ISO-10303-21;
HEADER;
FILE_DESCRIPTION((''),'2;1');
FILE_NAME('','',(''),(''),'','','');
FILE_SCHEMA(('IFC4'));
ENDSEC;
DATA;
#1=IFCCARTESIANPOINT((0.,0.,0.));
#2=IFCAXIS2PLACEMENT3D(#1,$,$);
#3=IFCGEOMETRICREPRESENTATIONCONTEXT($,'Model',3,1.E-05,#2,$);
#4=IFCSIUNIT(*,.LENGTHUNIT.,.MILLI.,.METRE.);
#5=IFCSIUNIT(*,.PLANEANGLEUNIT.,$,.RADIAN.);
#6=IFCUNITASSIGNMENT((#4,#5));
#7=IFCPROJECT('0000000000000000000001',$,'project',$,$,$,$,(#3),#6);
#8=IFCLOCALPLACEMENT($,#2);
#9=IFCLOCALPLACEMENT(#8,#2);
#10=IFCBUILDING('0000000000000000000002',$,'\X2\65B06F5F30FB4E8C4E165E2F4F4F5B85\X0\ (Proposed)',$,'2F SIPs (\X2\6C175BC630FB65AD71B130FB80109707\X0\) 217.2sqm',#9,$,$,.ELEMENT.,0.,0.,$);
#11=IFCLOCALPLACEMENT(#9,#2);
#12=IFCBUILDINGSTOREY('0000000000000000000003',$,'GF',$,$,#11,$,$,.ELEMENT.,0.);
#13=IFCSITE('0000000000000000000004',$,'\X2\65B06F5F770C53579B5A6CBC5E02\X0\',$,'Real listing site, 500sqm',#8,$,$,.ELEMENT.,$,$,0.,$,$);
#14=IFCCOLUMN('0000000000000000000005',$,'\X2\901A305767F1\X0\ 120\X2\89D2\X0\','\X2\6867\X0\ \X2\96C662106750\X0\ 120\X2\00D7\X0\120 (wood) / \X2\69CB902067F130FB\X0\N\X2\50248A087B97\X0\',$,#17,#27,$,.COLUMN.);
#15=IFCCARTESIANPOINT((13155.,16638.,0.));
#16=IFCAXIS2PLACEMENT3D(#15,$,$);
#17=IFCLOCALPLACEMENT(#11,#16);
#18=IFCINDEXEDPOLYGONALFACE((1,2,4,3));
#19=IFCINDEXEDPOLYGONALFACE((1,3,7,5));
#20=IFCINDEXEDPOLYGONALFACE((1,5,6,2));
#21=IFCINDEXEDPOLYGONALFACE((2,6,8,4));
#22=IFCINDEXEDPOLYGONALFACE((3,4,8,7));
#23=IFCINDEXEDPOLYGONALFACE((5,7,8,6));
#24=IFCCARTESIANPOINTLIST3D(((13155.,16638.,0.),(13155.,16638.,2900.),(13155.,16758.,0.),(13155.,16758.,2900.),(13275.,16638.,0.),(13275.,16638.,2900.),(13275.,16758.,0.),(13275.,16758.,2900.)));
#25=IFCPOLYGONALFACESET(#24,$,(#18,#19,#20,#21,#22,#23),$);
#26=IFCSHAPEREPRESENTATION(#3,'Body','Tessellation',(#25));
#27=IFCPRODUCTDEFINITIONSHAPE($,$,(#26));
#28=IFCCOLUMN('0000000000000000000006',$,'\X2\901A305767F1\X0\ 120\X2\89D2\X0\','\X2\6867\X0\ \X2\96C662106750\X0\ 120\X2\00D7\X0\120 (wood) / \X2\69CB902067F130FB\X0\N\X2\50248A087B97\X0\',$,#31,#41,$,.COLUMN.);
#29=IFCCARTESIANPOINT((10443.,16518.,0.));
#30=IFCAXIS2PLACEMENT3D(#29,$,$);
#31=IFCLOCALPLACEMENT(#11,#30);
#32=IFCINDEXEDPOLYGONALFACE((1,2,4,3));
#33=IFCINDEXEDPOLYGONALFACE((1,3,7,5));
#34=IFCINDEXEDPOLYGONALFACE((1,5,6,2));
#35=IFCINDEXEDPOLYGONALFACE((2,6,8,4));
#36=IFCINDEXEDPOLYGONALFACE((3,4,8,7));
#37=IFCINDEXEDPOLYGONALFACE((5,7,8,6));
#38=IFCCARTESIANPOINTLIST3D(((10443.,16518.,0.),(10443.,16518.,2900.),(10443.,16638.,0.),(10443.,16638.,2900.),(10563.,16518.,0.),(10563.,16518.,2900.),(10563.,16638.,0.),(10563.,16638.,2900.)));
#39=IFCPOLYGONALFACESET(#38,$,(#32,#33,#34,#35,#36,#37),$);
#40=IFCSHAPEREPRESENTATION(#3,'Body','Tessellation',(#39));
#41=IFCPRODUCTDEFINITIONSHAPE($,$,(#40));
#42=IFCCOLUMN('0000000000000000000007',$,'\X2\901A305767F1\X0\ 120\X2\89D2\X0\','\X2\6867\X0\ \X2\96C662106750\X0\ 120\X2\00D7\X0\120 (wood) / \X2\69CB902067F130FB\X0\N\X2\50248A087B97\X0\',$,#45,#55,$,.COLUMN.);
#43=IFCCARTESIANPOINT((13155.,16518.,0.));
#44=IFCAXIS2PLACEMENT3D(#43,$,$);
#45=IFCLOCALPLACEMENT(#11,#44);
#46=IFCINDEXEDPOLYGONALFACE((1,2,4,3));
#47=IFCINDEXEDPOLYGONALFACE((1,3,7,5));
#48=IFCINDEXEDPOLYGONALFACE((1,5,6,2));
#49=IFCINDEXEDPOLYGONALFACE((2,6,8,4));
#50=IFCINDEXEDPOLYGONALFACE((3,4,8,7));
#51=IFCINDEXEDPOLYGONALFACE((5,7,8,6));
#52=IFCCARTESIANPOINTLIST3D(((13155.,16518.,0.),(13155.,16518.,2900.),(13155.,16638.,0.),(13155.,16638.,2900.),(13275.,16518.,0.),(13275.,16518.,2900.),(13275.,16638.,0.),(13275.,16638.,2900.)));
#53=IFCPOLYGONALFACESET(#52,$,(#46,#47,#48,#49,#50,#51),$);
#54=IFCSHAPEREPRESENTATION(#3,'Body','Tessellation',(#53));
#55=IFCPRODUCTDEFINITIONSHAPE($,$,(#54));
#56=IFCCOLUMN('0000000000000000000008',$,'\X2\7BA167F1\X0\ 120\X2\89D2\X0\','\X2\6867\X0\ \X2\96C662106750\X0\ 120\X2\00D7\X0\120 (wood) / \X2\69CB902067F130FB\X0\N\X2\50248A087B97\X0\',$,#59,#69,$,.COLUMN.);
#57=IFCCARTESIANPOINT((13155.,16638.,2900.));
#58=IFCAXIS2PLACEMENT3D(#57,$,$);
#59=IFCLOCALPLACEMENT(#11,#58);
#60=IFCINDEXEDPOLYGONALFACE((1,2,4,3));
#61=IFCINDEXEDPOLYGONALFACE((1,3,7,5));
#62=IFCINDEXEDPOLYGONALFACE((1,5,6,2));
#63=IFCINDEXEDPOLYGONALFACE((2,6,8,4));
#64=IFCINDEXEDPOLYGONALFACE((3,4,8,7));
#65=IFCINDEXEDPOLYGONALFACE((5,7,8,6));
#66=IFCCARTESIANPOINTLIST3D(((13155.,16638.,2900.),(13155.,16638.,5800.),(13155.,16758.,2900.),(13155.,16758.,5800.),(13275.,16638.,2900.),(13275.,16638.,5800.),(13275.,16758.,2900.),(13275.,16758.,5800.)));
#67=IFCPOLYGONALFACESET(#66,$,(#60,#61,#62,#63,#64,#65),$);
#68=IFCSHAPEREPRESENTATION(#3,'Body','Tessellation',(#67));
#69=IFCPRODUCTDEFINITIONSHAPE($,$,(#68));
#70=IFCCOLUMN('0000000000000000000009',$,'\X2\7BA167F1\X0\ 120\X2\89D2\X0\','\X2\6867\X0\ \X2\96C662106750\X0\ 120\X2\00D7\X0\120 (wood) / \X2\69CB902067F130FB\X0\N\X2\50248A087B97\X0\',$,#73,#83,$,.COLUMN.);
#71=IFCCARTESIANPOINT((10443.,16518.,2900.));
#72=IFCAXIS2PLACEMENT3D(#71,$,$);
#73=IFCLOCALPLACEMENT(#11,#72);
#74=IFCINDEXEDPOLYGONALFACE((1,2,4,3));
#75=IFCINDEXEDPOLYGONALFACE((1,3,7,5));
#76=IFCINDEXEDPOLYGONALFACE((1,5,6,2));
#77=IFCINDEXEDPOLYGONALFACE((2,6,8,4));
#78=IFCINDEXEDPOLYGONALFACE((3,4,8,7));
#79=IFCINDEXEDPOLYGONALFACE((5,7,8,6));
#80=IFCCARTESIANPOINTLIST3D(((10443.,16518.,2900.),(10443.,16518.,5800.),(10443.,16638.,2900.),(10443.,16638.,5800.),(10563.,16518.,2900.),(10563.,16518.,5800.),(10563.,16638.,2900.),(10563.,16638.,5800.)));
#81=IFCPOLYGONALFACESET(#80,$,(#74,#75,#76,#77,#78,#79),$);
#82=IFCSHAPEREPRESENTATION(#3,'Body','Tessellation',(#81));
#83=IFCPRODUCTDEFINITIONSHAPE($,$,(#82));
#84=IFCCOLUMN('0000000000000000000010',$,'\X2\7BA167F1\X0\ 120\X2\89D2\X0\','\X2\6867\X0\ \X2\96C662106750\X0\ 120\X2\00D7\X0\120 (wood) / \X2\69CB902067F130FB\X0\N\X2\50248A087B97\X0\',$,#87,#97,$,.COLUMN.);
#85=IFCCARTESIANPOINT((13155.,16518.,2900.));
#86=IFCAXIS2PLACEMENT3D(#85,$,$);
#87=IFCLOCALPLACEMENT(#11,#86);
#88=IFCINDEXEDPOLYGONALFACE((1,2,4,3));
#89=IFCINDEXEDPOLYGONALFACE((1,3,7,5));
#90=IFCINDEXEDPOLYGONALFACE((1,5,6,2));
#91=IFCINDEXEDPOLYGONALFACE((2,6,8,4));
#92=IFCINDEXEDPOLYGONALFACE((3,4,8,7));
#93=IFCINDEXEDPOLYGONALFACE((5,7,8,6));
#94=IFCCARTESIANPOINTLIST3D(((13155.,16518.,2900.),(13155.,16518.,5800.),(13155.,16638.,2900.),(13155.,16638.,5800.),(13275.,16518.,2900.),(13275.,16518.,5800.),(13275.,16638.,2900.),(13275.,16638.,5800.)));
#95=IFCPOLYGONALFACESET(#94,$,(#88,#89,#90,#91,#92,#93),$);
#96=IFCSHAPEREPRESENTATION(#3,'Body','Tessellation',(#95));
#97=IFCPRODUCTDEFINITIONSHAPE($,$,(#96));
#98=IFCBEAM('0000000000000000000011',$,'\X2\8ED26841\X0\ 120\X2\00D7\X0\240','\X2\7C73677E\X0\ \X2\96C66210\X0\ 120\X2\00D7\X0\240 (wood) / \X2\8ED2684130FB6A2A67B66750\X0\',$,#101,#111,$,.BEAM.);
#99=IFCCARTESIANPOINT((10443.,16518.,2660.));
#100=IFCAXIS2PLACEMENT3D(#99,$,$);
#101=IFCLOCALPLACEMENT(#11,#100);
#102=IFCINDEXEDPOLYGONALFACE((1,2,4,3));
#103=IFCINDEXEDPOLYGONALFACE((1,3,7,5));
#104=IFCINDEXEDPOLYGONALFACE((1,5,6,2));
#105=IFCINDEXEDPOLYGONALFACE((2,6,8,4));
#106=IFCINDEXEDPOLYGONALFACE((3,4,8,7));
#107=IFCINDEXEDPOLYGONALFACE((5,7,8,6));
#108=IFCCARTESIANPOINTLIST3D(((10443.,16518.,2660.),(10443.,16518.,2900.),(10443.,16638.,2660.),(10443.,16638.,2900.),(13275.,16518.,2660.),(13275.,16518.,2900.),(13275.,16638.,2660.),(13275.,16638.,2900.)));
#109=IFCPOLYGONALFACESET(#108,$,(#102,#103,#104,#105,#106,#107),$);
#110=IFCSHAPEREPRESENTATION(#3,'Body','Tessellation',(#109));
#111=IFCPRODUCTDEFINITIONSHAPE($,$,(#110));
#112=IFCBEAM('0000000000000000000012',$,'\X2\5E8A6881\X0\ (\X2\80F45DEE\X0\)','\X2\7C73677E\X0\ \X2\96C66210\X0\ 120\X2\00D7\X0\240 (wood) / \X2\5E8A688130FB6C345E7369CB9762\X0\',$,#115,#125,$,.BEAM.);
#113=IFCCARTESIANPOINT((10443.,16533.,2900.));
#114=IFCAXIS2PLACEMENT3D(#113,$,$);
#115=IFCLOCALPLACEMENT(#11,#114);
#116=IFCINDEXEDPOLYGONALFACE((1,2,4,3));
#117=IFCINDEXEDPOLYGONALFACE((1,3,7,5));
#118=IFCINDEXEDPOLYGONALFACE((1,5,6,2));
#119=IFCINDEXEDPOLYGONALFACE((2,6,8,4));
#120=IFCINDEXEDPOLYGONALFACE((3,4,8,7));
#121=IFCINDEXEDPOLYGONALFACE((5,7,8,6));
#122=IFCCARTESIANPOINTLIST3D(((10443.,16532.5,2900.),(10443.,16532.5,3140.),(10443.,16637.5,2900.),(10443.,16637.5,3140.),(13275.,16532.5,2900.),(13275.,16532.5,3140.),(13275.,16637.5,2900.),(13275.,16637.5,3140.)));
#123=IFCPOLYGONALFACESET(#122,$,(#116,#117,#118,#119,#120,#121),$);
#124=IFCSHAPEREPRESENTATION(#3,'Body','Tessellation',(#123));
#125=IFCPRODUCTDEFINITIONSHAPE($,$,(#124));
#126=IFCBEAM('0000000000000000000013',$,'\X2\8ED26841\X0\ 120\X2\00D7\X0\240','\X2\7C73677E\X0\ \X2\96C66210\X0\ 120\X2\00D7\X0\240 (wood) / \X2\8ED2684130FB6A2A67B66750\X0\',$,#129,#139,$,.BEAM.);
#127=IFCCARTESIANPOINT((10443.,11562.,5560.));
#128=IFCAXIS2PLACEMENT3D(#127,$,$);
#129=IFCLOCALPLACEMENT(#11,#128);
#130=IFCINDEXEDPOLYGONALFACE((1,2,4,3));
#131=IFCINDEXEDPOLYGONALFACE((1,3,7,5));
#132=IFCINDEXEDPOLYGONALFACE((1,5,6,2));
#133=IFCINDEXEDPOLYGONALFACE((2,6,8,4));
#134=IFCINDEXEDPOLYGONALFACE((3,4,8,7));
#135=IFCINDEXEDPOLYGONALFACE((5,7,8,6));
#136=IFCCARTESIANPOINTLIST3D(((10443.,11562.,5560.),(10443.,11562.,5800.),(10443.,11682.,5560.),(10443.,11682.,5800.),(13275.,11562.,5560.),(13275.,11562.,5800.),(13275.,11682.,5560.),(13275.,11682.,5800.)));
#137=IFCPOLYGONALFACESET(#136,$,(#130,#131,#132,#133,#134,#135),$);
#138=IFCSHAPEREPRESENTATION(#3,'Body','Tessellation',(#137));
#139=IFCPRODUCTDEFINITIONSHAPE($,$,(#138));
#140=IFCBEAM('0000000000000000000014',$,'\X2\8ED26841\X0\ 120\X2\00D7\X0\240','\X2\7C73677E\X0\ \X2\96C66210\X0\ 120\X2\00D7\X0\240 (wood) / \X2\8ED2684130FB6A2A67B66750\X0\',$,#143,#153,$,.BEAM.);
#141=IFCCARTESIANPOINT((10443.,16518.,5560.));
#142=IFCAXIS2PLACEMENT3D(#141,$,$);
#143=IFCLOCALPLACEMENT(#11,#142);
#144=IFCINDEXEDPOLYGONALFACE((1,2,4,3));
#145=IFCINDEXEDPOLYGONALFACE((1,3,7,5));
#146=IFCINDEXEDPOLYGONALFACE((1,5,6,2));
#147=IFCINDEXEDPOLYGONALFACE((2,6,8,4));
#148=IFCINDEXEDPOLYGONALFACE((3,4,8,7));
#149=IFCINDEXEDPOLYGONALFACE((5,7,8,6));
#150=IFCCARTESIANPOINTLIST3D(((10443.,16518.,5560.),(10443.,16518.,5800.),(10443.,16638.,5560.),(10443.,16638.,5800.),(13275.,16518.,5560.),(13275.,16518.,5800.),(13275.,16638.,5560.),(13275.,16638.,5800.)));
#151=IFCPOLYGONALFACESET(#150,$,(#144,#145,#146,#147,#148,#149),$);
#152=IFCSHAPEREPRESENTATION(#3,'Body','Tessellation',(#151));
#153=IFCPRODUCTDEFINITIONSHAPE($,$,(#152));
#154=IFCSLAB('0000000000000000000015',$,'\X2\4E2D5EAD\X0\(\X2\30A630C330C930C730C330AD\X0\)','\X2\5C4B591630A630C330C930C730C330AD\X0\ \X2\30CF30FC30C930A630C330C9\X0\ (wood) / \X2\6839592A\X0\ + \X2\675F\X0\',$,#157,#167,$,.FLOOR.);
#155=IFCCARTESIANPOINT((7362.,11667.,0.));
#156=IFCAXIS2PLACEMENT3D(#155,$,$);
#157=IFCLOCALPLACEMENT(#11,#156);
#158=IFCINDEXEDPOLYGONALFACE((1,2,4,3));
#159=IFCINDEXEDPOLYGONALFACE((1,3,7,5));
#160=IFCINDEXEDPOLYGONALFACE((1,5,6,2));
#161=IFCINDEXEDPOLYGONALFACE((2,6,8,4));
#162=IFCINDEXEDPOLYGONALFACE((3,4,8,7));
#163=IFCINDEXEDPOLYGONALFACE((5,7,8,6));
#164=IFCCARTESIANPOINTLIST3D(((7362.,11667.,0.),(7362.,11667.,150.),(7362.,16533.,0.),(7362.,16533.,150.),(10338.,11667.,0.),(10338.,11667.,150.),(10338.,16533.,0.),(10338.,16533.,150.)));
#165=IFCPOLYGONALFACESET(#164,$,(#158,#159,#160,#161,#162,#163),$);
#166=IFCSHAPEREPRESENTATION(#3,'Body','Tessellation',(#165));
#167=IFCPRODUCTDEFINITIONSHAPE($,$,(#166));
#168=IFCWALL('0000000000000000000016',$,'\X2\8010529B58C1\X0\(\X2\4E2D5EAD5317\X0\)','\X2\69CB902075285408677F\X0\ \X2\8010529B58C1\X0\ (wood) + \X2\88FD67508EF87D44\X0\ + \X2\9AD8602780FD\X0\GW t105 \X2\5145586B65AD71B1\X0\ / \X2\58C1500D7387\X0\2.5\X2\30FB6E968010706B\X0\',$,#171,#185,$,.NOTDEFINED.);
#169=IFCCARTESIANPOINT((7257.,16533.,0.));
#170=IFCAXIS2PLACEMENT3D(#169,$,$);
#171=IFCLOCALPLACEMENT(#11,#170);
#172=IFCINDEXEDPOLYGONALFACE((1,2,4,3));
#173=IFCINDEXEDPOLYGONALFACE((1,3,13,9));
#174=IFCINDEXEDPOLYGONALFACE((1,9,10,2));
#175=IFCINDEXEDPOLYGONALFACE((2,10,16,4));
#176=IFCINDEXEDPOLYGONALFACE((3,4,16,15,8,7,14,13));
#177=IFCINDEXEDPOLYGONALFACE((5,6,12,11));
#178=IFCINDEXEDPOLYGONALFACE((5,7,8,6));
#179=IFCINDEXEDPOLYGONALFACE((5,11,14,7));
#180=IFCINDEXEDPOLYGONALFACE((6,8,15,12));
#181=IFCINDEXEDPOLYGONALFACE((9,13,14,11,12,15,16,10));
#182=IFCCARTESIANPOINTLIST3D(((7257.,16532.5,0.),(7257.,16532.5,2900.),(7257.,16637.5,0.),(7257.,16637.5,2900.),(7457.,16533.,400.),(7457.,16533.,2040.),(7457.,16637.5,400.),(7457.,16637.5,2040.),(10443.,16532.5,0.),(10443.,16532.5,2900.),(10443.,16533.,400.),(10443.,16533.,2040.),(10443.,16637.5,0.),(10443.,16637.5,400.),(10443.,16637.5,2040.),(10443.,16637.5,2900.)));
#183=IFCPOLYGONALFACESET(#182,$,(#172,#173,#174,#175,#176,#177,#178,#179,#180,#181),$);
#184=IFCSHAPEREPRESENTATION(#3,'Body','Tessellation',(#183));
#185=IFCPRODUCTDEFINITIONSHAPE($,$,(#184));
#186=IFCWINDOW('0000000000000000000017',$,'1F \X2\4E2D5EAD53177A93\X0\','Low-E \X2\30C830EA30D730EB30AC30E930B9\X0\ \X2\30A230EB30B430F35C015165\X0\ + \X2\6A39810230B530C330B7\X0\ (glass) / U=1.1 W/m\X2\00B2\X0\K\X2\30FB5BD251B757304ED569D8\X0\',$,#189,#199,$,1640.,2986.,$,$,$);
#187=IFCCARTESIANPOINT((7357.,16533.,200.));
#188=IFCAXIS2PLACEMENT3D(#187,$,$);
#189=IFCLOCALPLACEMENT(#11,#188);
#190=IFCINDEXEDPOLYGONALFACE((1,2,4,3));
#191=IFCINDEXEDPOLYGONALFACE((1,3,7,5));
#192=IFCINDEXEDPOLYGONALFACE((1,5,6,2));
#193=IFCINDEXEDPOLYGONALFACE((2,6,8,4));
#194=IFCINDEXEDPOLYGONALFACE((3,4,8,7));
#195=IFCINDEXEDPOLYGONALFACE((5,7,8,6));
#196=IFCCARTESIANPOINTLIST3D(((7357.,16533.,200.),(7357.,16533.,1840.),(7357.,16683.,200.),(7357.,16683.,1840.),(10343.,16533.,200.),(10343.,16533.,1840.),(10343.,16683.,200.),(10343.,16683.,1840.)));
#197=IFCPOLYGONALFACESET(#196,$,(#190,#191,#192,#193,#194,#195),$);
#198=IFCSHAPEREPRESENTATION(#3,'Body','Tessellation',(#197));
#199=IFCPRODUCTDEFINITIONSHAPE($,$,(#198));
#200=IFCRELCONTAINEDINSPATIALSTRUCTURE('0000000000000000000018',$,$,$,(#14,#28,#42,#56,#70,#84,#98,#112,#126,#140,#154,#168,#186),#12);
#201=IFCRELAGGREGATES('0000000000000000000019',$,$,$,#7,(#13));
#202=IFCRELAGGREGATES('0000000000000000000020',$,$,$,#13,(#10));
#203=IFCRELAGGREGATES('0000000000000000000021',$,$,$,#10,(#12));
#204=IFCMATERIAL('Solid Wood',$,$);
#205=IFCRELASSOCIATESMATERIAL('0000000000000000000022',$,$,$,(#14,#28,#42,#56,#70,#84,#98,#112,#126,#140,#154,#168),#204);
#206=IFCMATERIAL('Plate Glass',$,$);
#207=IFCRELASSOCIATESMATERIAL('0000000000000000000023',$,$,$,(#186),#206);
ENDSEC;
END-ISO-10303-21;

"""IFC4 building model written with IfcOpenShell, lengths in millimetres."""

from ifc_helpers import new_model, si_unit, frame, frame_2d, origin, place, context, project, spatial, rectangle, extrude, material, element, fill, save


model = new_model("IFC4")

# Units and contexts
model_context = context("Model", 3, precision=1e-05, world=origin())
ifc_project = project(units=[si_unit("LENGTHUNIT", "METRE", prefix="MILLI"), si_unit("PLANEANGLEUNIT", "RADIAN")], contexts=[model_context])

# Site, building, storey
site_placement = place(None, origin())
site = spatial("IfcSite", under=ifc_project, at=site_placement, Name="新潟県南魚沼市", ObjectType="Real listing site, 500sqm", CompositionType="ELEMENT", RefElevation=0.0)
building_placement = place(site_placement, origin())
building = spatial("IfcBuilding", under=site, at=building_placement, Name="新潟・二世帯住宅 (Proposed)", ObjectType="2F SIPs (気密・断熱・耐震) 217.2sqm", CompositionType="ELEMENT", ElevationOfRefHeight=0.0, ElevationOfTerrain=0.0)
storey_placement = place(building_placement, origin())
storey = spatial("IfcBuildingStorey", under=building, at=storey_placement, Name="GF", CompositionType="ELEMENT", Elevation=0.0)

# Columns
ifc_material_1 = material(Name="Solid Wood")
column_1_placement = place(storey_placement, frame((13155.0, 16638.0, 0.0)))
element("IfcColumn", 1, at=column_1_placement, inside=storey, material=ifc_material_1, Name="通し柱 120角", Description="桧 集成材 120×120 (wood) / 構造柱・N値計算", PredefinedType="COLUMN", context=model_context, shape_type="SweptSolid", body=[
    extrude(rectangle(XDim=120.0, YDim=120.0, at=frame_2d((60.0, 60.0))), frame((13155.0, 16638.0, 0.0)), (0.0, 0.0, 1.0), 2900.0),
])
column_2_placement = place(storey_placement, frame((10443.0, 16518.0, 0.0)))
element("IfcColumn", 2, at=column_2_placement, inside=storey, material=ifc_material_1, Name="通し柱 120角", Description="桧 集成材 120×120 (wood) / 構造柱・N値計算", PredefinedType="COLUMN", context=model_context, shape_type="SweptSolid", body=[
    extrude(rectangle(XDim=120.0, YDim=120.0, at=frame_2d((60.0, 60.0))), frame((10443.0, 16518.0, 0.0)), (0.0, 0.0, 1.0), 2900.0),
])
column_3_placement = place(storey_placement, frame((13155.0, 16518.0, 0.0)))
element("IfcColumn", 3, at=column_3_placement, inside=storey, material=ifc_material_1, Name="通し柱 120角", Description="桧 集成材 120×120 (wood) / 構造柱・N値計算", PredefinedType="COLUMN", context=model_context, shape_type="SweptSolid", body=[
    extrude(rectangle(XDim=120.0, YDim=120.0, at=frame_2d((60.0, 60.0))), frame((13155.0, 16518.0, 0.0)), (0.0, 0.0, 1.0), 2900.0),
])
column_4_placement = place(storey_placement, frame((13155.0, 16638.0, 2900.0)))
element("IfcColumn", 4, at=column_4_placement, inside=storey, material=ifc_material_1, Name="管柱 120角", Description="桧 集成材 120×120 (wood) / 構造柱・N値計算", PredefinedType="COLUMN", context=model_context, shape_type="SweptSolid", body=[
    extrude(rectangle(XDim=120.0, YDim=120.0, at=frame_2d((60.0, 60.0))), frame((13155.0, 16638.0, 2900.0)), (0.0, 0.0, 1.0), 2900.0),
])
column_5_placement = place(storey_placement, frame((10443.0, 16518.0, 2900.0)))
element("IfcColumn", 5, at=column_5_placement, inside=storey, material=ifc_material_1, Name="管柱 120角", Description="桧 集成材 120×120 (wood) / 構造柱・N値計算", PredefinedType="COLUMN", context=model_context, shape_type="SweptSolid", body=[
    extrude(rectangle(XDim=120.0, YDim=120.0, at=frame_2d((60.0, 60.0))), frame((10443.0, 16518.0, 2900.0)), (0.0, 0.0, 1.0), 2900.0),
])
column_6_placement = place(storey_placement, frame((13155.0, 16518.0, 2900.0)))
element("IfcColumn", 6, at=column_6_placement, inside=storey, material=ifc_material_1, Name="管柱 120角", Description="桧 集成材 120×120 (wood) / 構造柱・N値計算", PredefinedType="COLUMN", context=model_context, shape_type="SweptSolid", body=[
    extrude(rectangle(XDim=120.0, YDim=120.0, at=frame_2d((60.0, 60.0))), frame((13155.0, 16518.0, 2900.0)), (0.0, 0.0, 1.0), 2900.0),
])

# Beams
beam_1_placement = place(storey_placement, frame((10443.0, 16518.0, 2660.0)))
element("IfcBeam", 7, at=beam_1_placement, inside=storey, material=ifc_material_1, Name="軒桁 120×240", Description="米松 集成 120×240 (wood) / 軒桁・横架材", PredefinedType="BEAM", context=model_context, shape_type="SweptSolid", body=[
    extrude(rectangle(XDim=2832.0, YDim=120.0, at=frame_2d((1416.0, 60.0))), frame((10443.0, 16518.0, 2660.0)), (0.0, 0.0, 1.0), 240.0),
])
beam_2_placement = place(storey_placement, frame((10443.0, 16533.0, 2900.0)))
element("IfcBeam", 8, at=beam_2_placement, inside=storey, material=ifc_material_1, Name="床梁 (胴差)", Description="米松 集成 120×240 (wood) / 床梁・水平構面", PredefinedType="BEAM", context=model_context, shape_type="SweptSolid", body=[
    extrude(rectangle(XDim=2832.0, YDim=105.0, at=frame_2d((1416.0, 52.0))), frame((10443.0, 16533.0, 2900.0)), (0.0, 0.0, 1.0), 240.0),
])
beam_3_placement = place(storey_placement, frame((10443.0, 11562.0, 5560.0)))
element("IfcBeam", 9, at=beam_3_placement, inside=storey, material=ifc_material_1, Name="軒桁 120×240", Description="米松 集成 120×240 (wood) / 軒桁・横架材", PredefinedType="BEAM", context=model_context, shape_type="SweptSolid", body=[
    extrude(rectangle(XDim=2832.0, YDim=120.0, at=frame_2d((1416.0, 60.0))), frame((10443.0, 11562.0, 5560.0)), (0.0, 0.0, 1.0), 240.0),
])
beam_4_placement = place(storey_placement, frame((10443.0, 16518.0, 5560.0)))
element("IfcBeam", 10, at=beam_4_placement, inside=storey, material=ifc_material_1, Name="軒桁 120×240", Description="米松 集成 120×240 (wood) / 軒桁・横架材", PredefinedType="BEAM", context=model_context, shape_type="SweptSolid", body=[
    extrude(rectangle(XDim=2832.0, YDim=120.0, at=frame_2d((1416.0, 60.0))), frame((10443.0, 16518.0, 5560.0)), (0.0, 0.0, 1.0), 240.0),
])

# Slab
slab_placement = place(storey_placement, frame((7362.0, 11667.0, 0.0)))
element("IfcSlab", 11, at=slab_placement, inside=storey, material=ifc_material_1, Name="中庭(ウッドデッキ)", Description="屋外ウッドデッキ ハードウッド (wood) / 根太 + 束", PredefinedType="FLOOR", context=model_context, shape_type="SweptSolid", body=[
    extrude(rectangle(XDim=2976.0, YDim=4866.0, at=frame_2d((1488.0, 2433.0))), frame((7362.0, 11667.0, 0.0)), (0.0, 0.0, 1.0), 150.0),
])

# Wall, opening, window
wall_1_placement = place(storey_placement, frame((7257.0, 16533.0, 0.0)))
wall_1 = element("IfcWall", 12, at=wall_1_placement, inside=storey, material=ifc_material_1, Name="耐力壁(中庭北)", Description="構造用合板 耐力壁 (wood) + 製材軸組 + 高性能GW t105 充填断熱 / 壁倍率2.5・準耐火", PredefinedType="NOTDEFINED", context=model_context, shape_type="SweptSolid", body=[
    extrude(rectangle(XDim=3186.0, YDim=105.0, at=frame_2d((1593.0, 52.0))), frame((7257.0, 16533.0, 0.0)), (0.0, 0.0, 1.0), 2900.0),
])
opening_1_placement = place(storey_placement, frame((7357.0, 16533.0, 200.0)))
opening_1 = element("IfcOpeningElement", 13, at=opening_1_placement, cuts=wall_1, PredefinedType="NOTDEFINED", context=model_context, shape_type="SweptSolid", body=[
    extrude(rectangle(XDim=2986.0, YDim=150.0, at=frame_2d((1493.0, 75.0))), frame((7357.0, 16533.0, 200.0)), (0.0, 0.0, 1.0), 1640.0),
])
ifc_material_2 = material(Name="Plate Glass")
window_1_placement = place(storey_placement, frame((7357.0, 16533.0, 200.0)))
window_1 = element("IfcWindow", 14, at=window_1_placement, inside=storey, material=ifc_material_2, Name="1F 中庭北窓", Description="Low-E トリプルガラス アルゴン封入 + 樹脂サッシ (glass) / U=1.1 W/m²K・寒冷地仕様", OverallHeight=1640.0, OverallWidth=2986.0, context=model_context, shape_type="SweptSolid", body=[
    extrude(rectangle(XDim=2986.0, YDim=150.0, at=frame_2d((1493.0, 75.0))), frame((7357.0, 16533.0, 200.0)), (0.0, 0.0, 1.0), 1640.0),
])
fill(opening_1, window_1)

save(model, "model.ifc")
